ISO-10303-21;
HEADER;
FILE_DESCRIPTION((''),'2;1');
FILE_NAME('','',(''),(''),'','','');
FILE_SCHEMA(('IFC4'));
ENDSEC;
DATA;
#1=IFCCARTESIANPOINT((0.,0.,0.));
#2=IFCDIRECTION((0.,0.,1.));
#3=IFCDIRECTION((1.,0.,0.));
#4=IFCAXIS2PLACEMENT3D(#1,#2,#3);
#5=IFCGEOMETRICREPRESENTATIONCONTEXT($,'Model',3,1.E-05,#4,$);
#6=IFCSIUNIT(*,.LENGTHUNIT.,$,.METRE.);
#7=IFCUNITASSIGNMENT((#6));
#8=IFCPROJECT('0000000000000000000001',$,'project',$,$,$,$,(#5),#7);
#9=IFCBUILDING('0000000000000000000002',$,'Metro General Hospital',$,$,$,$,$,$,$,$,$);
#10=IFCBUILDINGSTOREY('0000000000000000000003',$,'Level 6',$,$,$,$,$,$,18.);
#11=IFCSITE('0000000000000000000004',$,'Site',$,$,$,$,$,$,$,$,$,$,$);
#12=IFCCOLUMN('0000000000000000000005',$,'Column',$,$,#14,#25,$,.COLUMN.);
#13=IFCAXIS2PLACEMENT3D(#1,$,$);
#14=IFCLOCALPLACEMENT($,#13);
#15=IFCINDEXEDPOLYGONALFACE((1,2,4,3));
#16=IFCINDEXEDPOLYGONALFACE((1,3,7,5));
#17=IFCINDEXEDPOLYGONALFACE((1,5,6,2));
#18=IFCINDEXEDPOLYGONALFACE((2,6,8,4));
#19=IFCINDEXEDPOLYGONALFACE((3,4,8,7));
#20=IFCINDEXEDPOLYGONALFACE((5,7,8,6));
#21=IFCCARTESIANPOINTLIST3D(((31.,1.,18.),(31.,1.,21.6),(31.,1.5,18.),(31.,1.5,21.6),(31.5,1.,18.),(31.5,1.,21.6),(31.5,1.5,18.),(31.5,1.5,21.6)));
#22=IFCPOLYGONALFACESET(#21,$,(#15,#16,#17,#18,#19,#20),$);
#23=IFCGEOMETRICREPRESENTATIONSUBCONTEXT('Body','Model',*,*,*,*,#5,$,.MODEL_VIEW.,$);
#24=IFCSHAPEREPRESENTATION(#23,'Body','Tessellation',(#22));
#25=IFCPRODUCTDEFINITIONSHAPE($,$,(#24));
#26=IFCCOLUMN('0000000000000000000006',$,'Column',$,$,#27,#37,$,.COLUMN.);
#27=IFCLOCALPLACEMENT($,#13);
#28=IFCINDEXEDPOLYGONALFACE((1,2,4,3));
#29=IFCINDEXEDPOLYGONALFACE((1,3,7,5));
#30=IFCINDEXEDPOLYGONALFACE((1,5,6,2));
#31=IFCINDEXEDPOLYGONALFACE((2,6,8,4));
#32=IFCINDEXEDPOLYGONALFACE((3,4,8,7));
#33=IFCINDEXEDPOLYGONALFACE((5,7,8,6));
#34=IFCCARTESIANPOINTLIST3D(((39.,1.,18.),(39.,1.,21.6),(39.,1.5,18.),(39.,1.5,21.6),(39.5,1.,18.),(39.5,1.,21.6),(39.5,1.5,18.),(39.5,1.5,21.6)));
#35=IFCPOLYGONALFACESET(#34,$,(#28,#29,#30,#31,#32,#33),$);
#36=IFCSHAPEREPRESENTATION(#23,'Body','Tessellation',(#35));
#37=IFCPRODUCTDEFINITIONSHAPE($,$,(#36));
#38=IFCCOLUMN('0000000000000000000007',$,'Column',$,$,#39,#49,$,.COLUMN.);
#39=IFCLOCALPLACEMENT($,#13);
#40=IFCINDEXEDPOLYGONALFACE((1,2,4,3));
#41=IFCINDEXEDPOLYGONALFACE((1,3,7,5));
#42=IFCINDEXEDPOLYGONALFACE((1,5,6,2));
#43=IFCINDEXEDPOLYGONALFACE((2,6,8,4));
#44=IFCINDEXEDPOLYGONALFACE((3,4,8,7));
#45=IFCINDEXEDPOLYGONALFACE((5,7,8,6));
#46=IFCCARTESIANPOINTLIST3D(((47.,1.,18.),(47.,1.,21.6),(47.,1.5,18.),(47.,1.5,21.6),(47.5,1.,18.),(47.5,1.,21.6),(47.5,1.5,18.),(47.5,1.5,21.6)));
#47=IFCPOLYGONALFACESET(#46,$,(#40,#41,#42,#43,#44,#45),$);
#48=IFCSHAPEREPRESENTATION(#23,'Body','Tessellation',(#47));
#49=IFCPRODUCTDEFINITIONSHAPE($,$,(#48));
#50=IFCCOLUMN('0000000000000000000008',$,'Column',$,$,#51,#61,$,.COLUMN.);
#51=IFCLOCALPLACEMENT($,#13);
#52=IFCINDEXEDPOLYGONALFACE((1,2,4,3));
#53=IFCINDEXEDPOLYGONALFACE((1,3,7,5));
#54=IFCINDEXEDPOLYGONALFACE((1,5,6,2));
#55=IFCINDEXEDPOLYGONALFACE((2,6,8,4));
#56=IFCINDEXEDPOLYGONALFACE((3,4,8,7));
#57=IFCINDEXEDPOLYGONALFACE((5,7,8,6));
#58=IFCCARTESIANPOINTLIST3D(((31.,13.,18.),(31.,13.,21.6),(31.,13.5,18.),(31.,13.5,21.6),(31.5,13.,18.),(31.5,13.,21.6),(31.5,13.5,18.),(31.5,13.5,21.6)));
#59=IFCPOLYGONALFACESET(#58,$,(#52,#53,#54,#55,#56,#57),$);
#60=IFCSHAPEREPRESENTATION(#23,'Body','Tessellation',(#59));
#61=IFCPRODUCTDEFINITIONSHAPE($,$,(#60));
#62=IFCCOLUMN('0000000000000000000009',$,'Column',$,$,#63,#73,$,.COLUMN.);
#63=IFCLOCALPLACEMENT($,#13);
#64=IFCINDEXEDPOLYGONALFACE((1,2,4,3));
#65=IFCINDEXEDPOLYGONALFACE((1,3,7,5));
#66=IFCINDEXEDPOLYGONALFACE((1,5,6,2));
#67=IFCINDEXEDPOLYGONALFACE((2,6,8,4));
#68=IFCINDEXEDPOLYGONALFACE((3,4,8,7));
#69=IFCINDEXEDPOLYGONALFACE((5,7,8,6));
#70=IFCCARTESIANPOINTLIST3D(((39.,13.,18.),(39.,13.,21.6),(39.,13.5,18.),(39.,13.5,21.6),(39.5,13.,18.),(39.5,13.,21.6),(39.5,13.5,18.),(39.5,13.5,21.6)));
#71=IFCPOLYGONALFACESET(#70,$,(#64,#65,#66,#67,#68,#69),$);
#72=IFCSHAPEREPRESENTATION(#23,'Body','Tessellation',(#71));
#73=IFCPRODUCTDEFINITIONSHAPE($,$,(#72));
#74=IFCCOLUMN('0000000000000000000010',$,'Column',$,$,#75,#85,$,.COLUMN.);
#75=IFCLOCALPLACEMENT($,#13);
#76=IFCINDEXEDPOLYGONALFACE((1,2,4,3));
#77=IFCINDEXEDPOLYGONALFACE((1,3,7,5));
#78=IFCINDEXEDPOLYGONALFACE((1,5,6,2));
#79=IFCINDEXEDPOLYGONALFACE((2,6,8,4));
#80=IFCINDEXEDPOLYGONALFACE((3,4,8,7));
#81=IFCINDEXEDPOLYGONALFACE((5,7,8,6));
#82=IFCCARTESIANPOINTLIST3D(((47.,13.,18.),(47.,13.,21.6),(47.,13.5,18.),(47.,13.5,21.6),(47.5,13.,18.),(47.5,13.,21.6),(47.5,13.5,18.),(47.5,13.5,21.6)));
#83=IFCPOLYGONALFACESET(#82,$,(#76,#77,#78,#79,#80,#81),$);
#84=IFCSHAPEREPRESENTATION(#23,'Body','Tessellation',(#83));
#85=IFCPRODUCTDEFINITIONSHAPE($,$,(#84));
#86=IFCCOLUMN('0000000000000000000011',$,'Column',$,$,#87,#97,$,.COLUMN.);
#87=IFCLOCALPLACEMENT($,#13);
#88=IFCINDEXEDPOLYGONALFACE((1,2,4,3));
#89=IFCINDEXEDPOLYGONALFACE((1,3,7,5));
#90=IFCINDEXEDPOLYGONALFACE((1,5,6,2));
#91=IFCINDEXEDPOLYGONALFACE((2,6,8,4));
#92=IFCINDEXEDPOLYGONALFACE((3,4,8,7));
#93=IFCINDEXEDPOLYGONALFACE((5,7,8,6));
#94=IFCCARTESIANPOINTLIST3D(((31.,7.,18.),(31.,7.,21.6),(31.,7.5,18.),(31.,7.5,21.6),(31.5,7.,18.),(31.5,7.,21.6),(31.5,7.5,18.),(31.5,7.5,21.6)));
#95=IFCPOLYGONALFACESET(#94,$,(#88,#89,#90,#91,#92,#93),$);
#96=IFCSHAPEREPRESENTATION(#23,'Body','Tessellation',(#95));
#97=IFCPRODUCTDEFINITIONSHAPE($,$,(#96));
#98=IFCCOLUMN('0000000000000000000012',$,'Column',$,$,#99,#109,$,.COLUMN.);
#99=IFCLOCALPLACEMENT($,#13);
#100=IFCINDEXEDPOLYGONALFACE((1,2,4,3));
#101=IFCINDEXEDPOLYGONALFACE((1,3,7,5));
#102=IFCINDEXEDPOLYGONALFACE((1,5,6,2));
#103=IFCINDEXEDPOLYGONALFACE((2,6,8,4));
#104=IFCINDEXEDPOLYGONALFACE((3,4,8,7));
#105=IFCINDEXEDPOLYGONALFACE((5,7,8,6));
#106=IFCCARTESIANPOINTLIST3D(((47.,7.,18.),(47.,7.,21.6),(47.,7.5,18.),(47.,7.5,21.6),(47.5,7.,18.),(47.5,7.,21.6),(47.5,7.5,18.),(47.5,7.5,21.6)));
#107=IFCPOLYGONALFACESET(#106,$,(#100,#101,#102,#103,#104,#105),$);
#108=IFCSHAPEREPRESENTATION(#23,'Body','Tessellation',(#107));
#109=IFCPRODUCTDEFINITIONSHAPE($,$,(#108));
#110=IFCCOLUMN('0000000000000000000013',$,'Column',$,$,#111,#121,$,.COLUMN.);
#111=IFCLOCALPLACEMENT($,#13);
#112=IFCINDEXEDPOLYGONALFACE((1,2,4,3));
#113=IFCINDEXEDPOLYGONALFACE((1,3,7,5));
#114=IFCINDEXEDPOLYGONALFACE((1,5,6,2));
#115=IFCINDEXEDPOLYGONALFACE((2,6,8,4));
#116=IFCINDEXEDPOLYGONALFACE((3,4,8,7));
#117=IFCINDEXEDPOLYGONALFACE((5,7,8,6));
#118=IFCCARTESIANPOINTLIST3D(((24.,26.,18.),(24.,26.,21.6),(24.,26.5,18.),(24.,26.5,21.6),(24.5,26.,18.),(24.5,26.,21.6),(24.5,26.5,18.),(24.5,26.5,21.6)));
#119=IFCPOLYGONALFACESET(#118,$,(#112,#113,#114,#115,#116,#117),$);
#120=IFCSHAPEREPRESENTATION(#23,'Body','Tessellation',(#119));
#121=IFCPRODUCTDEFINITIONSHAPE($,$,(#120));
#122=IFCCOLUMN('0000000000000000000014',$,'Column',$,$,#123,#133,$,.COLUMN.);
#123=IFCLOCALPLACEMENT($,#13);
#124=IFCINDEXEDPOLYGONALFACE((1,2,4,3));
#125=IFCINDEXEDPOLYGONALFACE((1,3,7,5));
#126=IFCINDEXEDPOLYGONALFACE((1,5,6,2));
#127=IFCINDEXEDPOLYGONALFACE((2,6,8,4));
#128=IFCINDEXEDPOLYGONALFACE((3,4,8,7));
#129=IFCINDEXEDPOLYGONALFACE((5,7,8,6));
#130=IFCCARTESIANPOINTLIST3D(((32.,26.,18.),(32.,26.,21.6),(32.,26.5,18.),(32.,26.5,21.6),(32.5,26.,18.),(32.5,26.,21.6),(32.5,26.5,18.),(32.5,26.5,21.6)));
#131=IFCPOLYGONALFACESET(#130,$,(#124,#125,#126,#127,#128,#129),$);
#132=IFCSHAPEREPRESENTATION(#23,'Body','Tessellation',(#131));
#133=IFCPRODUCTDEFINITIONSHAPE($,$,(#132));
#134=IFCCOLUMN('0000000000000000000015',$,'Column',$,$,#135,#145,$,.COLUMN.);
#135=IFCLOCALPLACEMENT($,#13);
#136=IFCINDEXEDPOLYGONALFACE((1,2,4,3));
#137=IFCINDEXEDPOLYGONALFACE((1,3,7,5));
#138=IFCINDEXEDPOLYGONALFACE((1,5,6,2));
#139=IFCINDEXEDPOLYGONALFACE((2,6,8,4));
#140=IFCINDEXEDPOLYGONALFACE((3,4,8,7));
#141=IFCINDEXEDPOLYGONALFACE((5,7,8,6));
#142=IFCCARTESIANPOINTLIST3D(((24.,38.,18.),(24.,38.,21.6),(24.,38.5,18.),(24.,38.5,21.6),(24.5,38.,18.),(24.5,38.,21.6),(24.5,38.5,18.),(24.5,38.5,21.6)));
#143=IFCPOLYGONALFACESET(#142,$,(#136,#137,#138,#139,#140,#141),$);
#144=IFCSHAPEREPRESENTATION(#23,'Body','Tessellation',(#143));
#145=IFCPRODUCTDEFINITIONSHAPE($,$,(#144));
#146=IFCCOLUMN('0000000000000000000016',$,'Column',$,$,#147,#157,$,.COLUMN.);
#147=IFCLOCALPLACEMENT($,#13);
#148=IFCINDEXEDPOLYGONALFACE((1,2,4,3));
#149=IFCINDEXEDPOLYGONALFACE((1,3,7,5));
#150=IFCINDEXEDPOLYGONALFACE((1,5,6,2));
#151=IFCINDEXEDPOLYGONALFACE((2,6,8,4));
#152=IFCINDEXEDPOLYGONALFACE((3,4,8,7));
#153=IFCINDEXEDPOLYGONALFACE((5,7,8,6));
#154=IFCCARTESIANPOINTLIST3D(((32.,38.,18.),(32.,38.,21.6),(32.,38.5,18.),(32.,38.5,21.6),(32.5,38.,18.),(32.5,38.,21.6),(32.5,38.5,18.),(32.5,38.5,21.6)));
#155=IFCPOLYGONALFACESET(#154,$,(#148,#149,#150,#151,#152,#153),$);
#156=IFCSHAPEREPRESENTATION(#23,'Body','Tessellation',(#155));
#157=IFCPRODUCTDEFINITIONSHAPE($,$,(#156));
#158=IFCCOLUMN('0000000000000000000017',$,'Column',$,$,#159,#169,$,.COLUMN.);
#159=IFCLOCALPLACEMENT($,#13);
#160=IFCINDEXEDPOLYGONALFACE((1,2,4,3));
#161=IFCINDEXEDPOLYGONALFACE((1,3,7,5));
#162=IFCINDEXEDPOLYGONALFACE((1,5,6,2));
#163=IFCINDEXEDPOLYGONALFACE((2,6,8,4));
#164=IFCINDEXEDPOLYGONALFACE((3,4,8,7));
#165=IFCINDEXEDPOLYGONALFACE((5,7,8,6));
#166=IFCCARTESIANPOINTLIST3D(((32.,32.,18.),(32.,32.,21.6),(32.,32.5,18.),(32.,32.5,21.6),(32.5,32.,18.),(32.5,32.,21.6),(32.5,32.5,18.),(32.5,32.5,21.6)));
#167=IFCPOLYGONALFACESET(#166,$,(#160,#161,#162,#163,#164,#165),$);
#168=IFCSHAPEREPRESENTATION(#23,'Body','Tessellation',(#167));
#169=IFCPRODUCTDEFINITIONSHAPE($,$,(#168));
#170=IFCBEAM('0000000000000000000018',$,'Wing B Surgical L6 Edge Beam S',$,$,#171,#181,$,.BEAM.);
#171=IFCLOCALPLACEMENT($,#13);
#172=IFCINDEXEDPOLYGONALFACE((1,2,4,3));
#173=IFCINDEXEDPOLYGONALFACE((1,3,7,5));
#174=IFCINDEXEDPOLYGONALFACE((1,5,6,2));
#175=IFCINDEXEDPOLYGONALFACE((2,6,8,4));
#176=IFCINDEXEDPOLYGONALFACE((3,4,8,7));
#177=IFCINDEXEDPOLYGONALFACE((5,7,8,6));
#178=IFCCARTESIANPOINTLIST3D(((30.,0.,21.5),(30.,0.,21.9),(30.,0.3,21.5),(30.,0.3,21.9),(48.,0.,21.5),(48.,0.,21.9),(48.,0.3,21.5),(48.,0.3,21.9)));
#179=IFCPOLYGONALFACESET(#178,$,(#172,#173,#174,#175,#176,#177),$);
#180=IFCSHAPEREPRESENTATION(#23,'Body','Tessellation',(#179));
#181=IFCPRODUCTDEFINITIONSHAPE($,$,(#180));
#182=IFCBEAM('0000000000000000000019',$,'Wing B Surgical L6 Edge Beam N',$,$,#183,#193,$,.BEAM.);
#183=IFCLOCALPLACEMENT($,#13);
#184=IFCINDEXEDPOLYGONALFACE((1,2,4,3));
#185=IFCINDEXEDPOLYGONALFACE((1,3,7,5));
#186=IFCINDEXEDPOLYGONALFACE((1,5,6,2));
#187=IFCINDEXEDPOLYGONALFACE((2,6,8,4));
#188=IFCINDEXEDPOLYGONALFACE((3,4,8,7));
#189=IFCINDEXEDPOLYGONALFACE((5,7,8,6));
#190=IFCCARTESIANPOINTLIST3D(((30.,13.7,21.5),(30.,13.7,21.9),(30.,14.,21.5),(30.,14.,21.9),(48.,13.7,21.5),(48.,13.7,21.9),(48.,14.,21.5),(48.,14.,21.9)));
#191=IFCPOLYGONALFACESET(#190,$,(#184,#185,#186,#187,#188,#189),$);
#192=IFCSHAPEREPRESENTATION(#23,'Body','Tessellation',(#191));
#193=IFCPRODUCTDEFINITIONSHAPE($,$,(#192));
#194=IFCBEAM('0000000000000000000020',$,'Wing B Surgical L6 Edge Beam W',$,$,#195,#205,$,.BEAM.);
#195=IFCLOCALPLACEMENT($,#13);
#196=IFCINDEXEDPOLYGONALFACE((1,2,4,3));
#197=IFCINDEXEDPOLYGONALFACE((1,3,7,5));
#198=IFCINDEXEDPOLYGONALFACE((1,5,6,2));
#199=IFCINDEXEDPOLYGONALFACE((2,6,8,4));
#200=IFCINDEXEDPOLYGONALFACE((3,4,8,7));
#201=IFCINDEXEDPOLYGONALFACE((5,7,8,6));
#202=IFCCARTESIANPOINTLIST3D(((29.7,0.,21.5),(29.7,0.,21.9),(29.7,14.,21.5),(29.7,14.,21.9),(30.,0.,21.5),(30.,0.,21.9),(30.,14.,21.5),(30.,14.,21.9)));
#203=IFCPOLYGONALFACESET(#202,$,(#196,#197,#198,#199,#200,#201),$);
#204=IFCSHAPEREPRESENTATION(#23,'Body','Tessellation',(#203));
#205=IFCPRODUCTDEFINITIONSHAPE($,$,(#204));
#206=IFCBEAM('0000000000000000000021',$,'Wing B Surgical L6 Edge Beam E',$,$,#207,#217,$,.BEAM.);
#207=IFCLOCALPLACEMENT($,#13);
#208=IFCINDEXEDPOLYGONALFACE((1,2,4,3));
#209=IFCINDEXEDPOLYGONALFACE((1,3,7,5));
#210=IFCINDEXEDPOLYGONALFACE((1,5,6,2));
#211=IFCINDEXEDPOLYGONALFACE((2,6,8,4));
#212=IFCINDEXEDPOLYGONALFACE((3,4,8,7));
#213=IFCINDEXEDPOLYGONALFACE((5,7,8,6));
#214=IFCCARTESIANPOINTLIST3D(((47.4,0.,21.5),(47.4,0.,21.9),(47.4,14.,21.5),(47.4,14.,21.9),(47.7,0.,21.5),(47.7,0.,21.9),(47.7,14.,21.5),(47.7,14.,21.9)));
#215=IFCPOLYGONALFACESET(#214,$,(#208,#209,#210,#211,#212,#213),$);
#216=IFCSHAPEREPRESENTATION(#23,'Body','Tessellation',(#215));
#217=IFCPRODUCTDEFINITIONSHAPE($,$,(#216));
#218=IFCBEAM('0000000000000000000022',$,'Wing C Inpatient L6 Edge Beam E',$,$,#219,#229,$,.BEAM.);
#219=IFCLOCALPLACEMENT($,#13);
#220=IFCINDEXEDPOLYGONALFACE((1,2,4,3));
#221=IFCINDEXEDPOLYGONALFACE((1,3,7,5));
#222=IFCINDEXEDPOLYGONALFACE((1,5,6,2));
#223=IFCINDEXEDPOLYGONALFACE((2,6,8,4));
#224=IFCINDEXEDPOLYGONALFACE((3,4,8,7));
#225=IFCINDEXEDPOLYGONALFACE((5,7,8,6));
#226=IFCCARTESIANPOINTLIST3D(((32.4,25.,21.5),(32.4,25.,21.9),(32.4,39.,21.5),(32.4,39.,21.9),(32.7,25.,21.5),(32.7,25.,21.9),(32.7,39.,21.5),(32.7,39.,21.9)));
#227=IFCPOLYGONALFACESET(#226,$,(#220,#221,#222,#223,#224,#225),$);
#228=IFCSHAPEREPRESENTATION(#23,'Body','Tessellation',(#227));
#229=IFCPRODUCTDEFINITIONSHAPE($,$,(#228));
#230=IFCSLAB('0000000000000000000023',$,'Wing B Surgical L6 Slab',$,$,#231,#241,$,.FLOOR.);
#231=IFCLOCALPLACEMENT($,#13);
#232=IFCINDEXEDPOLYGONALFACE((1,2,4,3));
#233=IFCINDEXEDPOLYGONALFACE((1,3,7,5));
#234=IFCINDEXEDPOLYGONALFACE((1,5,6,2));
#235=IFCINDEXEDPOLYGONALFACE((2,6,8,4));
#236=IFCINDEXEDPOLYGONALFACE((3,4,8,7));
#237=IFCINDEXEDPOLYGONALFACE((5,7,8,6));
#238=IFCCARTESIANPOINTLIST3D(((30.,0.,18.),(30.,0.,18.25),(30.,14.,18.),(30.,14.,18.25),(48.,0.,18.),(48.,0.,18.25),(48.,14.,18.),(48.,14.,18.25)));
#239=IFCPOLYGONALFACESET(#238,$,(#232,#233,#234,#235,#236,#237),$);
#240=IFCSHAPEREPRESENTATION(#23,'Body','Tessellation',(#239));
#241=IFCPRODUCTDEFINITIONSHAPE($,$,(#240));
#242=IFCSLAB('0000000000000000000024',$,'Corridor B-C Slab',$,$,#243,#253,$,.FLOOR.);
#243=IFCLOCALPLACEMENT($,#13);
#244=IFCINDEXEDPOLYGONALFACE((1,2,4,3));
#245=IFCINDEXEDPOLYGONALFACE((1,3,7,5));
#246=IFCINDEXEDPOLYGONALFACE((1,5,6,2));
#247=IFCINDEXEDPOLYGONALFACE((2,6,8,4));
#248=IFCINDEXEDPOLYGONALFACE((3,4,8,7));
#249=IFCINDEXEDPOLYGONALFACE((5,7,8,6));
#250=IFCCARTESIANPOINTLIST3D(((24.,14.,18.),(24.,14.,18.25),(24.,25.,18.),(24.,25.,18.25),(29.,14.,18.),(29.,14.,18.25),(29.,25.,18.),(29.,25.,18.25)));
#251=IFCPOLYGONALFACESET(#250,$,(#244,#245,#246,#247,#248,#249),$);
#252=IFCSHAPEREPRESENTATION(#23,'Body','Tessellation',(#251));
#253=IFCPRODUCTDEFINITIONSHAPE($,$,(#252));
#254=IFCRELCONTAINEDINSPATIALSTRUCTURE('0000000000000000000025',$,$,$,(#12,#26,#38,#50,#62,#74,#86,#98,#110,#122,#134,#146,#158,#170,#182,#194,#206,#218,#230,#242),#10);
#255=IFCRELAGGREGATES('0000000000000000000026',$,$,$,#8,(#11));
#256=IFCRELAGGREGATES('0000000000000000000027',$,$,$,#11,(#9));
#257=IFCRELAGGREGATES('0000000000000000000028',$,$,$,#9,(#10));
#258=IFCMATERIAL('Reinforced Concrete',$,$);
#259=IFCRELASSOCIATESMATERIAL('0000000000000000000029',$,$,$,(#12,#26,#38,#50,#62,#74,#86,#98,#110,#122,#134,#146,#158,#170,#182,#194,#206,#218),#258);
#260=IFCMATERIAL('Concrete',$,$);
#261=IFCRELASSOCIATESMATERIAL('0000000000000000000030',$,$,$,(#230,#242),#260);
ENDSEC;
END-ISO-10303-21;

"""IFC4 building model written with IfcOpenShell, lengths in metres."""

from ifc_helpers import new_model, si_unit, frame, origin_with_axes, place, context, subcontext, project, spatial, line, indexed_curve, outline, extrude, material, element, save


model = new_model("IFC4")

# Units and contexts
model_context = context("Model", 3, precision=1e-05, world=origin_with_axes())
body_context = subcontext(model_context, "Body", "Model", "MODEL_VIEW")
ifc_project = project(units=[si_unit("LENGTHUNIT", "METRE")], contexts=[model_context])

# Site, building, storey
site = spatial("IfcSite", under=ifc_project, Name="Site")
building = spatial("IfcBuilding", under=site, Name="Metro General Hospital")
storey = spatial("IfcBuildingStorey", under=building, Name="Level 6", Elevation=18.0)

# Columns
ifc_material_1 = material(Name="Reinforced Concrete")
for number, where, z_axis, x_axis, name in (
    (1, (31.0, 1.0, 18.0), (0.0, 0.0, 1.0), (1.0, 0.0, 0.0), "Column"),
    (2, (39.0, 1.0, 18.0), (0.0, 0.0, 1.0), (1.0, 0.0, 0.0), "Column"),
    (3, (47.0, 1.0, 18.0), (0.0, 0.0, 1.0), (1.0, 0.0, 0.0), "Column"),
    (4, (31.0, 13.0, 18.0), (0.0, 0.0, 1.0), (1.0, 0.0, 0.0), "Column"),
    (5, (39.0, 13.0, 18.0), (0.0, 0.0, 1.0), (1.0, 0.0, 0.0), "Column"),
    (6, (47.0, 13.0, 18.0), (0.0, 0.0, 1.0), (1.0, 0.0, 0.0), "Column"),
    (7, (31.0, 7.0, 18.0), (0.0, 0.0, 1.0), (1.0, 0.0, 0.0), "Column"),
    (8, (47.0, 7.0, 18.0), (0.0, 0.0, 1.0), (1.0, 0.0, 0.0), "Column"),
    (9, (24.0, 26.0, 18.0), (0.0, 0.0, 1.0), (1.0, 0.0, 0.0), "Column"),
    (10, (32.0, 26.0, 18.0), (0.0, 0.0, 1.0), (1.0, 0.0, 0.0), "Column"),
    (11, (24.0, 38.0, 18.0), (0.0, 0.0, 1.0), (1.0, 0.0, 0.0), "Column"),
    (12, (32.0, 38.0, 18.0), (0.0, 0.0, 1.0), (1.0, 0.0, 0.0), "Column"),
    (13, (32.0, 32.0, 18.0), (0.0, 0.0, 1.0), (1.0, 0.0, 0.0), "Column"),
):
    element("IfcColumn", number, at=place(None, frame(where, z_axis=z_axis, x_axis=x_axis)), inside=storey, material=ifc_material_1, Name=name, PredefinedType="COLUMN", context=body_context, shape_type="SweptSolid", body=[
        extrude(outline(indexed_curve([(0.0, 0.0), (0.5, 0.0), (0.5, 0.5), (0.0, 0.5)], segments=[line(1, 2, 3, 4, 1)])), origin_with_axes(), (0.0, 0.0, 1.0), 3.6),
    ])

# Beams
for number, where, z_axis, x_axis, name in (
    (14, (30.0, 0.0, 21.5), (0.0, 0.0, 1.0), (1.0, 0.0, 0.0), "Wing B Surgical L6 Edge Beam S"),
    (15, (30.0, 13.7, 21.5), (0.0, 0.0, 1.0), (1.0, 0.0, 0.0), "Wing B Surgical L6 Edge Beam N"),
):
    element("IfcBeam", number, at=place(None, frame(where, z_axis=z_axis, x_axis=x_axis)), inside=storey, material=ifc_material_1, Name=name, PredefinedType="BEAM", context=body_context, shape_type="SweptSolid", body=[
        extrude(outline(indexed_curve([(0.0, 0.0), (18.0, 0.0), (18.0, 0.3), (0.0, 0.3)], segments=[line(1, 2, 3, 4, 1)])), origin_with_axes(), (0.0, 0.0, 1.0), 0.4),
    ])
for number, where, z_axis, x_axis, name in (
    (16, (30.0, 0.0, 21.5), (0.0, 0.0, 1.0), (0.0, 1.0, 0.0), "Wing B Surgical L6 Edge Beam W"),
    (17, (47.7, 0.0, 21.5), (0.0, 0.0, 1.0), (0.0, 1.0, 0.0), "Wing B Surgical L6 Edge Beam E"),
    (18, (32.7, 25.0, 21.5), (0.0, 0.0, 1.0), (0.0, 1.0, 0.0), "Wing C Inpatient L6 Edge Beam E"),
):
    element("IfcBeam", number, at=place(None, frame(where, z_axis=z_axis, x_axis=x_axis)), inside=storey, material=ifc_material_1, Name=name, PredefinedType="BEAM", context=body_context, shape_type="SweptSolid", body=[
        extrude(outline(indexed_curve([(0.0, 0.0), (14.0, 0.0), (14.0, 0.3), (0.0, 0.3)], segments=[line(1, 2, 3, 4, 1)])), origin_with_axes(), (0.0, 0.0, 1.0), 0.4),
    ])

# Slabs
ifc_material_2 = material(Name="Concrete")
slab_1_placement = place(None, frame((30.0, 0.0, 18.0), z_axis=(0.0, 0.0, 1.0), x_axis=(1.0, 0.0, 0.0)))
element("IfcSlab", 19, at=slab_1_placement, inside=storey, material=ifc_material_2, Name="Wing B Surgical L6 Slab", PredefinedType="FLOOR", context=body_context, shape_type="SweptSolid", body=[
    extrude(outline(indexed_curve([(0.0, 0.0), (18.0, 0.0), (18.0, 14.0), (0.0, 14.0)], segments=[line(1, 2, 3, 4, 1)])), origin_with_axes(), (0.0, 0.0, 1.0), 0.25),
])
slab_2_placement = place(None, frame((24.0, 14.0, 18.0), z_axis=(0.0, 0.0, 1.0), x_axis=(1.0, 0.0, 0.0)))
element("IfcSlab", 20, at=slab_2_placement, inside=storey, material=ifc_material_2, Name="Corridor B-C Slab", PredefinedType="FLOOR", context=body_context, shape_type="SweptSolid", body=[
    extrude(outline(indexed_curve([(0.0, 0.0), (5.0, 0.0), (5.0, 11.0), (0.0, 11.0)], segments=[line(1, 2, 3, 4, 1)])), origin_with_axes(), (0.0, 0.0, 1.0), 0.25),
])

save(model, "model.ifc")
